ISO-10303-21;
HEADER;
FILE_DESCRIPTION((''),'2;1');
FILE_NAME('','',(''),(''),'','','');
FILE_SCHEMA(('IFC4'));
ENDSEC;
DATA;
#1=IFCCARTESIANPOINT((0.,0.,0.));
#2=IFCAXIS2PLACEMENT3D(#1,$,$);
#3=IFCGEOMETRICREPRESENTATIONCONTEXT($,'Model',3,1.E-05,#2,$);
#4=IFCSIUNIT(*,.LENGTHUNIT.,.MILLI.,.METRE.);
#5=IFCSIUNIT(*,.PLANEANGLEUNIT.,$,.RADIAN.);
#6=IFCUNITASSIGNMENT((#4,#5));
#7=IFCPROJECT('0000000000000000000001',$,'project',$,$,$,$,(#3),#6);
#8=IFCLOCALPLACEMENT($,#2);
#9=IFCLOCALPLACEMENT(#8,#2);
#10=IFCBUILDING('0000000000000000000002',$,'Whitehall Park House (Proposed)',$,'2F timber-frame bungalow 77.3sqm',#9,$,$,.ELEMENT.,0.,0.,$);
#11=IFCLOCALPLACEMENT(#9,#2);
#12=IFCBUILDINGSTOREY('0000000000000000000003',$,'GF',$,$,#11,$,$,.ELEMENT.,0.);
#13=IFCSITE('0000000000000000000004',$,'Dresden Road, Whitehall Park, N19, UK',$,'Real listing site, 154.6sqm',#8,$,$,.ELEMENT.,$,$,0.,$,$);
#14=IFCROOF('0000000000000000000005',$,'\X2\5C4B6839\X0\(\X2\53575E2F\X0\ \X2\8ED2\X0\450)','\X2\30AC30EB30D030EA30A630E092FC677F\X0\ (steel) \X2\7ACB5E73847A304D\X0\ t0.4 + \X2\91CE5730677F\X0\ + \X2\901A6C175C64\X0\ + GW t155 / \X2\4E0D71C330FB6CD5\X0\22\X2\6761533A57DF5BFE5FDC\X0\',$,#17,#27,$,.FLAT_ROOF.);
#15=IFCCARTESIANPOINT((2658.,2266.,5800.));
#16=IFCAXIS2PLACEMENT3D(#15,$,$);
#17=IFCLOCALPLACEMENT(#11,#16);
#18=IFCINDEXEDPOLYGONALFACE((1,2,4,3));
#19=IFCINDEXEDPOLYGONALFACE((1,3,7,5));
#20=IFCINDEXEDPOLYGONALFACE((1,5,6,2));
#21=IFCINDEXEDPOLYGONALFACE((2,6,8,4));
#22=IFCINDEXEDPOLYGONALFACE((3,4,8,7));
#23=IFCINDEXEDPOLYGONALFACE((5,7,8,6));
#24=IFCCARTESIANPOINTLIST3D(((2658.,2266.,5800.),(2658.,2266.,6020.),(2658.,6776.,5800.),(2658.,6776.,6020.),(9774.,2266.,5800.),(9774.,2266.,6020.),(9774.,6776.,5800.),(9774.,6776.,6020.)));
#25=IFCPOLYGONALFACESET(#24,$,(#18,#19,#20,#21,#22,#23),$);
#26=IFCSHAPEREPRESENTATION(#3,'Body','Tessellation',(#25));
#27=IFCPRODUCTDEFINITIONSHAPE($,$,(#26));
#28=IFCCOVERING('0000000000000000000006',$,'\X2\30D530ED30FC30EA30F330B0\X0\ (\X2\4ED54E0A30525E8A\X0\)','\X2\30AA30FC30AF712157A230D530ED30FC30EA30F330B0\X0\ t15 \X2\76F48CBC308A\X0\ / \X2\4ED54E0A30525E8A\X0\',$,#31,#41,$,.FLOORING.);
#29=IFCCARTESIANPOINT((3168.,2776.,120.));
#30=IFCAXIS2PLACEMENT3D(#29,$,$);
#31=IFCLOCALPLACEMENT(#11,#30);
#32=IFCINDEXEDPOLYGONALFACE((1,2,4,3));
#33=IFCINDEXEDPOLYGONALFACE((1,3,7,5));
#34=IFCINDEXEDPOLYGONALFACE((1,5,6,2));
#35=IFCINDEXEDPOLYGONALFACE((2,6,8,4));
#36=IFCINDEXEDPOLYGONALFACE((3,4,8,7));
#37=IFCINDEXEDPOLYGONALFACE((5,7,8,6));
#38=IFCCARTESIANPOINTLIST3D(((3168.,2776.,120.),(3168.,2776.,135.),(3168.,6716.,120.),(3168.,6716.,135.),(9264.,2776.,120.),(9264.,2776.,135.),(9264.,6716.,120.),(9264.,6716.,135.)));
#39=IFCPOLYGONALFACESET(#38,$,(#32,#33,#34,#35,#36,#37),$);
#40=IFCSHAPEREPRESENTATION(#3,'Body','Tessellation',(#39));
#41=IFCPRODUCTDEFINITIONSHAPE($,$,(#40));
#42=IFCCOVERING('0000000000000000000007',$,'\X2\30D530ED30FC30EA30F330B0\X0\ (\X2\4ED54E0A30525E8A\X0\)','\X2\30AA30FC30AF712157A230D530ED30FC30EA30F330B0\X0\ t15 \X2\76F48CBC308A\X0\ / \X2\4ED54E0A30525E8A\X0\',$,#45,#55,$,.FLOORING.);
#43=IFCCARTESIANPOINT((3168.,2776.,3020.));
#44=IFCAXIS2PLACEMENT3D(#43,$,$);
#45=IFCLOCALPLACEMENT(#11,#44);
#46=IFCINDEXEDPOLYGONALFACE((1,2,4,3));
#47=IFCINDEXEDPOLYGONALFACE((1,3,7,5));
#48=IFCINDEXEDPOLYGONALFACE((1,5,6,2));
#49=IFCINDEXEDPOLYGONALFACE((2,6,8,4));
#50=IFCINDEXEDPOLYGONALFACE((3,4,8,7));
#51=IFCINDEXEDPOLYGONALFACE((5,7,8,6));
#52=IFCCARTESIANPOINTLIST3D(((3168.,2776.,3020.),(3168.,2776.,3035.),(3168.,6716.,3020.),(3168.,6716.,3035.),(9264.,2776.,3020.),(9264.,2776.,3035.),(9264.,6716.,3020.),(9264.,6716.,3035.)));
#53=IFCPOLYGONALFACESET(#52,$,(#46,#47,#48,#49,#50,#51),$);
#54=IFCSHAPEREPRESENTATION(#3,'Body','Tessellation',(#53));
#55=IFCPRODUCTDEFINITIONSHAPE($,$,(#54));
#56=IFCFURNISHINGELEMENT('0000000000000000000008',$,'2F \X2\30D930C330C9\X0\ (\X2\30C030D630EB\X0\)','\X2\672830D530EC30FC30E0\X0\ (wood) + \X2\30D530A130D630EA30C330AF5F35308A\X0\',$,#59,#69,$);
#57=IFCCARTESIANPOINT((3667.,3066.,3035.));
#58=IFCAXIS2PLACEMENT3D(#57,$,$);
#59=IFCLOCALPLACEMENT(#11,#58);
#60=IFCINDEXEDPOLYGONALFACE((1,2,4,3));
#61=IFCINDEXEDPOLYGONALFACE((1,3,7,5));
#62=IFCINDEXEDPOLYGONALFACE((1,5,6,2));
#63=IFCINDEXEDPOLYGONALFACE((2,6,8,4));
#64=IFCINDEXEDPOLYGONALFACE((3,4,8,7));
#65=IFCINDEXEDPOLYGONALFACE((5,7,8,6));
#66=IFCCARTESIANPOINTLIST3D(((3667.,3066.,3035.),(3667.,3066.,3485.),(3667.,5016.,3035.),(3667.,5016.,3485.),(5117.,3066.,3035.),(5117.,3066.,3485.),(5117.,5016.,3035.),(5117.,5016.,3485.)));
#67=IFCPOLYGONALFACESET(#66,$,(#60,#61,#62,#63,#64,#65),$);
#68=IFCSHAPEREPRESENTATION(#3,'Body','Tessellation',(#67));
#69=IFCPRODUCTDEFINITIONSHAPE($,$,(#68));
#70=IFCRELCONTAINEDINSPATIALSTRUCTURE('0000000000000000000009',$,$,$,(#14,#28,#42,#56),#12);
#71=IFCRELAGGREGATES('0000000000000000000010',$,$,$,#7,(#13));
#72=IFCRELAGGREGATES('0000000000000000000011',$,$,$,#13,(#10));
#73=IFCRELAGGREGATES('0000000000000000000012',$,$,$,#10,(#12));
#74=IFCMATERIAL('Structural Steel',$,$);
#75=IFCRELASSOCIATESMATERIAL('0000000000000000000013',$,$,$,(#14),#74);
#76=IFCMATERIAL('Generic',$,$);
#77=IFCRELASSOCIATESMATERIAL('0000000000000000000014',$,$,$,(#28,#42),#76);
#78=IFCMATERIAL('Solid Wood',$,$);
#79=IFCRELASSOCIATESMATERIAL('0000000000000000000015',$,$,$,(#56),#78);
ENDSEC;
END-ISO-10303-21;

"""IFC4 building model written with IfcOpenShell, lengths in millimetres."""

from ifc_helpers import new_model, si_unit, frame, frame_2d, origin, place, context, project, spatial, rectangle, extrude, material, element, save


model = new_model("IFC4")

# Units and contexts
model_context = context("Model", 3, precision=1e-05, world=origin())
ifc_project = project(units=[si_unit("LENGTHUNIT", "METRE", prefix="MILLI"), si_unit("PLANEANGLEUNIT", "RADIAN")], contexts=[model_context])

# Site, building, storey
site_placement = place(None, origin())
site = spatial("IfcSite", under=ifc_project, at=site_placement, Name="Dresden Road, Whitehall Park, N19, UK", ObjectType="Real listing site, 154.6sqm", CompositionType="ELEMENT", RefElevation=0.0)
building_placement = place(site_placement, origin())
building = spatial("IfcBuilding", under=site, at=building_placement, Name="Whitehall Park House (Proposed)", ObjectType="2F timber-frame bungalow 77.3sqm", CompositionType="ELEMENT", ElevationOfRefHeight=0.0, ElevationOfTerrain=0.0)
storey_placement = place(building_placement, origin())
storey = spatial("IfcBuildingStorey", under=building, at=storey_placement, Name="GF", CompositionType="ELEMENT", Elevation=0.0)

# Shared definitions
ifc_material_1 = material(Name="Solid Wood")

# Roof
ifc_material_2 = material(Name="Structural Steel")
for number, where, name in (
    (1, (2658.0, 2266.0, 5800.0), "屋根(南帯 軒450)"),
):
    element("IfcRoof", number, at=place(storey_placement, frame(where)), inside=storey, material=ifc_material_2, Name=name, Description="ガルバリウム鋼板 (steel) 立平葺き t0.4 + 野地板 + 通気層 + GW t155 / 不燃・法22条区域対応", PredefinedType="FLAT_ROOF", context=model_context, shape_type="SweptSolid", body=[
        extrude(rectangle(XDim=7116.0, YDim=4510.0, at=frame_2d((3558.0, 2255.0))), frame((2658.0, 2266.0, 5800.0)), (0.0, 0.0, 1.0), 220.0),
    ])

# Coverings
ifc_material_3 = material(Name="Generic")
covering_1_placement = place(storey_placement, frame((3168.0, 2776.0, 120.0)))
element("IfcCovering", 2, at=covering_1_placement, inside=storey, material=ifc_material_3, Name="フローリング (仕上げ床)", Description="オーク無垢フローリング t15 直貼り / 仕上げ床", PredefinedType="FLOORING", context=model_context, shape_type="SweptSolid", body=[
    extrude(rectangle(XDim=6096.0, YDim=3940.0, at=frame_2d((3048.0, 1970.0))), frame((3168.0, 2776.0, 120.0)), (0.0, 0.0, 1.0), 15.0),
])
covering_2_placement = place(storey_placement, frame((3168.0, 2776.0, 3020.0)))
element("IfcCovering", 3, at=covering_2_placement, inside=storey, material=ifc_material_3, Name="フローリング (仕上げ床)", Description="オーク無垢フローリング t15 直貼り / 仕上げ床", PredefinedType="FLOORING", context=model_context, shape_type="SweptSolid", body=[
    extrude(rectangle(XDim=6096.0, YDim=3940.0, at=frame_2d((3048.0, 1970.0))), frame((3168.0, 2776.0, 3020.0)), (0.0, 0.0, 1.0), 15.0),
])

# Furnishing element
furnishing_placement = place(storey_placement, frame((3667.0, 3066.0, 3035.0)))
element("IfcFurnishingElement", 4, at=furnishing_placement, inside=storey, material=ifc_material_1, Name="2F ベッド (ダブル)", Description="木フレーム (wood) + ファブリック張り", context=model_context, shape_type="SweptSolid", body=[
    extrude(rectangle(XDim=1450.0, YDim=1950.0, at=frame_2d((725.0, 975.0))), frame((3667.0, 3066.0, 3035.0)), (0.0, 0.0, 1.0), 450.0),
])

save(model, "model.ifc")
